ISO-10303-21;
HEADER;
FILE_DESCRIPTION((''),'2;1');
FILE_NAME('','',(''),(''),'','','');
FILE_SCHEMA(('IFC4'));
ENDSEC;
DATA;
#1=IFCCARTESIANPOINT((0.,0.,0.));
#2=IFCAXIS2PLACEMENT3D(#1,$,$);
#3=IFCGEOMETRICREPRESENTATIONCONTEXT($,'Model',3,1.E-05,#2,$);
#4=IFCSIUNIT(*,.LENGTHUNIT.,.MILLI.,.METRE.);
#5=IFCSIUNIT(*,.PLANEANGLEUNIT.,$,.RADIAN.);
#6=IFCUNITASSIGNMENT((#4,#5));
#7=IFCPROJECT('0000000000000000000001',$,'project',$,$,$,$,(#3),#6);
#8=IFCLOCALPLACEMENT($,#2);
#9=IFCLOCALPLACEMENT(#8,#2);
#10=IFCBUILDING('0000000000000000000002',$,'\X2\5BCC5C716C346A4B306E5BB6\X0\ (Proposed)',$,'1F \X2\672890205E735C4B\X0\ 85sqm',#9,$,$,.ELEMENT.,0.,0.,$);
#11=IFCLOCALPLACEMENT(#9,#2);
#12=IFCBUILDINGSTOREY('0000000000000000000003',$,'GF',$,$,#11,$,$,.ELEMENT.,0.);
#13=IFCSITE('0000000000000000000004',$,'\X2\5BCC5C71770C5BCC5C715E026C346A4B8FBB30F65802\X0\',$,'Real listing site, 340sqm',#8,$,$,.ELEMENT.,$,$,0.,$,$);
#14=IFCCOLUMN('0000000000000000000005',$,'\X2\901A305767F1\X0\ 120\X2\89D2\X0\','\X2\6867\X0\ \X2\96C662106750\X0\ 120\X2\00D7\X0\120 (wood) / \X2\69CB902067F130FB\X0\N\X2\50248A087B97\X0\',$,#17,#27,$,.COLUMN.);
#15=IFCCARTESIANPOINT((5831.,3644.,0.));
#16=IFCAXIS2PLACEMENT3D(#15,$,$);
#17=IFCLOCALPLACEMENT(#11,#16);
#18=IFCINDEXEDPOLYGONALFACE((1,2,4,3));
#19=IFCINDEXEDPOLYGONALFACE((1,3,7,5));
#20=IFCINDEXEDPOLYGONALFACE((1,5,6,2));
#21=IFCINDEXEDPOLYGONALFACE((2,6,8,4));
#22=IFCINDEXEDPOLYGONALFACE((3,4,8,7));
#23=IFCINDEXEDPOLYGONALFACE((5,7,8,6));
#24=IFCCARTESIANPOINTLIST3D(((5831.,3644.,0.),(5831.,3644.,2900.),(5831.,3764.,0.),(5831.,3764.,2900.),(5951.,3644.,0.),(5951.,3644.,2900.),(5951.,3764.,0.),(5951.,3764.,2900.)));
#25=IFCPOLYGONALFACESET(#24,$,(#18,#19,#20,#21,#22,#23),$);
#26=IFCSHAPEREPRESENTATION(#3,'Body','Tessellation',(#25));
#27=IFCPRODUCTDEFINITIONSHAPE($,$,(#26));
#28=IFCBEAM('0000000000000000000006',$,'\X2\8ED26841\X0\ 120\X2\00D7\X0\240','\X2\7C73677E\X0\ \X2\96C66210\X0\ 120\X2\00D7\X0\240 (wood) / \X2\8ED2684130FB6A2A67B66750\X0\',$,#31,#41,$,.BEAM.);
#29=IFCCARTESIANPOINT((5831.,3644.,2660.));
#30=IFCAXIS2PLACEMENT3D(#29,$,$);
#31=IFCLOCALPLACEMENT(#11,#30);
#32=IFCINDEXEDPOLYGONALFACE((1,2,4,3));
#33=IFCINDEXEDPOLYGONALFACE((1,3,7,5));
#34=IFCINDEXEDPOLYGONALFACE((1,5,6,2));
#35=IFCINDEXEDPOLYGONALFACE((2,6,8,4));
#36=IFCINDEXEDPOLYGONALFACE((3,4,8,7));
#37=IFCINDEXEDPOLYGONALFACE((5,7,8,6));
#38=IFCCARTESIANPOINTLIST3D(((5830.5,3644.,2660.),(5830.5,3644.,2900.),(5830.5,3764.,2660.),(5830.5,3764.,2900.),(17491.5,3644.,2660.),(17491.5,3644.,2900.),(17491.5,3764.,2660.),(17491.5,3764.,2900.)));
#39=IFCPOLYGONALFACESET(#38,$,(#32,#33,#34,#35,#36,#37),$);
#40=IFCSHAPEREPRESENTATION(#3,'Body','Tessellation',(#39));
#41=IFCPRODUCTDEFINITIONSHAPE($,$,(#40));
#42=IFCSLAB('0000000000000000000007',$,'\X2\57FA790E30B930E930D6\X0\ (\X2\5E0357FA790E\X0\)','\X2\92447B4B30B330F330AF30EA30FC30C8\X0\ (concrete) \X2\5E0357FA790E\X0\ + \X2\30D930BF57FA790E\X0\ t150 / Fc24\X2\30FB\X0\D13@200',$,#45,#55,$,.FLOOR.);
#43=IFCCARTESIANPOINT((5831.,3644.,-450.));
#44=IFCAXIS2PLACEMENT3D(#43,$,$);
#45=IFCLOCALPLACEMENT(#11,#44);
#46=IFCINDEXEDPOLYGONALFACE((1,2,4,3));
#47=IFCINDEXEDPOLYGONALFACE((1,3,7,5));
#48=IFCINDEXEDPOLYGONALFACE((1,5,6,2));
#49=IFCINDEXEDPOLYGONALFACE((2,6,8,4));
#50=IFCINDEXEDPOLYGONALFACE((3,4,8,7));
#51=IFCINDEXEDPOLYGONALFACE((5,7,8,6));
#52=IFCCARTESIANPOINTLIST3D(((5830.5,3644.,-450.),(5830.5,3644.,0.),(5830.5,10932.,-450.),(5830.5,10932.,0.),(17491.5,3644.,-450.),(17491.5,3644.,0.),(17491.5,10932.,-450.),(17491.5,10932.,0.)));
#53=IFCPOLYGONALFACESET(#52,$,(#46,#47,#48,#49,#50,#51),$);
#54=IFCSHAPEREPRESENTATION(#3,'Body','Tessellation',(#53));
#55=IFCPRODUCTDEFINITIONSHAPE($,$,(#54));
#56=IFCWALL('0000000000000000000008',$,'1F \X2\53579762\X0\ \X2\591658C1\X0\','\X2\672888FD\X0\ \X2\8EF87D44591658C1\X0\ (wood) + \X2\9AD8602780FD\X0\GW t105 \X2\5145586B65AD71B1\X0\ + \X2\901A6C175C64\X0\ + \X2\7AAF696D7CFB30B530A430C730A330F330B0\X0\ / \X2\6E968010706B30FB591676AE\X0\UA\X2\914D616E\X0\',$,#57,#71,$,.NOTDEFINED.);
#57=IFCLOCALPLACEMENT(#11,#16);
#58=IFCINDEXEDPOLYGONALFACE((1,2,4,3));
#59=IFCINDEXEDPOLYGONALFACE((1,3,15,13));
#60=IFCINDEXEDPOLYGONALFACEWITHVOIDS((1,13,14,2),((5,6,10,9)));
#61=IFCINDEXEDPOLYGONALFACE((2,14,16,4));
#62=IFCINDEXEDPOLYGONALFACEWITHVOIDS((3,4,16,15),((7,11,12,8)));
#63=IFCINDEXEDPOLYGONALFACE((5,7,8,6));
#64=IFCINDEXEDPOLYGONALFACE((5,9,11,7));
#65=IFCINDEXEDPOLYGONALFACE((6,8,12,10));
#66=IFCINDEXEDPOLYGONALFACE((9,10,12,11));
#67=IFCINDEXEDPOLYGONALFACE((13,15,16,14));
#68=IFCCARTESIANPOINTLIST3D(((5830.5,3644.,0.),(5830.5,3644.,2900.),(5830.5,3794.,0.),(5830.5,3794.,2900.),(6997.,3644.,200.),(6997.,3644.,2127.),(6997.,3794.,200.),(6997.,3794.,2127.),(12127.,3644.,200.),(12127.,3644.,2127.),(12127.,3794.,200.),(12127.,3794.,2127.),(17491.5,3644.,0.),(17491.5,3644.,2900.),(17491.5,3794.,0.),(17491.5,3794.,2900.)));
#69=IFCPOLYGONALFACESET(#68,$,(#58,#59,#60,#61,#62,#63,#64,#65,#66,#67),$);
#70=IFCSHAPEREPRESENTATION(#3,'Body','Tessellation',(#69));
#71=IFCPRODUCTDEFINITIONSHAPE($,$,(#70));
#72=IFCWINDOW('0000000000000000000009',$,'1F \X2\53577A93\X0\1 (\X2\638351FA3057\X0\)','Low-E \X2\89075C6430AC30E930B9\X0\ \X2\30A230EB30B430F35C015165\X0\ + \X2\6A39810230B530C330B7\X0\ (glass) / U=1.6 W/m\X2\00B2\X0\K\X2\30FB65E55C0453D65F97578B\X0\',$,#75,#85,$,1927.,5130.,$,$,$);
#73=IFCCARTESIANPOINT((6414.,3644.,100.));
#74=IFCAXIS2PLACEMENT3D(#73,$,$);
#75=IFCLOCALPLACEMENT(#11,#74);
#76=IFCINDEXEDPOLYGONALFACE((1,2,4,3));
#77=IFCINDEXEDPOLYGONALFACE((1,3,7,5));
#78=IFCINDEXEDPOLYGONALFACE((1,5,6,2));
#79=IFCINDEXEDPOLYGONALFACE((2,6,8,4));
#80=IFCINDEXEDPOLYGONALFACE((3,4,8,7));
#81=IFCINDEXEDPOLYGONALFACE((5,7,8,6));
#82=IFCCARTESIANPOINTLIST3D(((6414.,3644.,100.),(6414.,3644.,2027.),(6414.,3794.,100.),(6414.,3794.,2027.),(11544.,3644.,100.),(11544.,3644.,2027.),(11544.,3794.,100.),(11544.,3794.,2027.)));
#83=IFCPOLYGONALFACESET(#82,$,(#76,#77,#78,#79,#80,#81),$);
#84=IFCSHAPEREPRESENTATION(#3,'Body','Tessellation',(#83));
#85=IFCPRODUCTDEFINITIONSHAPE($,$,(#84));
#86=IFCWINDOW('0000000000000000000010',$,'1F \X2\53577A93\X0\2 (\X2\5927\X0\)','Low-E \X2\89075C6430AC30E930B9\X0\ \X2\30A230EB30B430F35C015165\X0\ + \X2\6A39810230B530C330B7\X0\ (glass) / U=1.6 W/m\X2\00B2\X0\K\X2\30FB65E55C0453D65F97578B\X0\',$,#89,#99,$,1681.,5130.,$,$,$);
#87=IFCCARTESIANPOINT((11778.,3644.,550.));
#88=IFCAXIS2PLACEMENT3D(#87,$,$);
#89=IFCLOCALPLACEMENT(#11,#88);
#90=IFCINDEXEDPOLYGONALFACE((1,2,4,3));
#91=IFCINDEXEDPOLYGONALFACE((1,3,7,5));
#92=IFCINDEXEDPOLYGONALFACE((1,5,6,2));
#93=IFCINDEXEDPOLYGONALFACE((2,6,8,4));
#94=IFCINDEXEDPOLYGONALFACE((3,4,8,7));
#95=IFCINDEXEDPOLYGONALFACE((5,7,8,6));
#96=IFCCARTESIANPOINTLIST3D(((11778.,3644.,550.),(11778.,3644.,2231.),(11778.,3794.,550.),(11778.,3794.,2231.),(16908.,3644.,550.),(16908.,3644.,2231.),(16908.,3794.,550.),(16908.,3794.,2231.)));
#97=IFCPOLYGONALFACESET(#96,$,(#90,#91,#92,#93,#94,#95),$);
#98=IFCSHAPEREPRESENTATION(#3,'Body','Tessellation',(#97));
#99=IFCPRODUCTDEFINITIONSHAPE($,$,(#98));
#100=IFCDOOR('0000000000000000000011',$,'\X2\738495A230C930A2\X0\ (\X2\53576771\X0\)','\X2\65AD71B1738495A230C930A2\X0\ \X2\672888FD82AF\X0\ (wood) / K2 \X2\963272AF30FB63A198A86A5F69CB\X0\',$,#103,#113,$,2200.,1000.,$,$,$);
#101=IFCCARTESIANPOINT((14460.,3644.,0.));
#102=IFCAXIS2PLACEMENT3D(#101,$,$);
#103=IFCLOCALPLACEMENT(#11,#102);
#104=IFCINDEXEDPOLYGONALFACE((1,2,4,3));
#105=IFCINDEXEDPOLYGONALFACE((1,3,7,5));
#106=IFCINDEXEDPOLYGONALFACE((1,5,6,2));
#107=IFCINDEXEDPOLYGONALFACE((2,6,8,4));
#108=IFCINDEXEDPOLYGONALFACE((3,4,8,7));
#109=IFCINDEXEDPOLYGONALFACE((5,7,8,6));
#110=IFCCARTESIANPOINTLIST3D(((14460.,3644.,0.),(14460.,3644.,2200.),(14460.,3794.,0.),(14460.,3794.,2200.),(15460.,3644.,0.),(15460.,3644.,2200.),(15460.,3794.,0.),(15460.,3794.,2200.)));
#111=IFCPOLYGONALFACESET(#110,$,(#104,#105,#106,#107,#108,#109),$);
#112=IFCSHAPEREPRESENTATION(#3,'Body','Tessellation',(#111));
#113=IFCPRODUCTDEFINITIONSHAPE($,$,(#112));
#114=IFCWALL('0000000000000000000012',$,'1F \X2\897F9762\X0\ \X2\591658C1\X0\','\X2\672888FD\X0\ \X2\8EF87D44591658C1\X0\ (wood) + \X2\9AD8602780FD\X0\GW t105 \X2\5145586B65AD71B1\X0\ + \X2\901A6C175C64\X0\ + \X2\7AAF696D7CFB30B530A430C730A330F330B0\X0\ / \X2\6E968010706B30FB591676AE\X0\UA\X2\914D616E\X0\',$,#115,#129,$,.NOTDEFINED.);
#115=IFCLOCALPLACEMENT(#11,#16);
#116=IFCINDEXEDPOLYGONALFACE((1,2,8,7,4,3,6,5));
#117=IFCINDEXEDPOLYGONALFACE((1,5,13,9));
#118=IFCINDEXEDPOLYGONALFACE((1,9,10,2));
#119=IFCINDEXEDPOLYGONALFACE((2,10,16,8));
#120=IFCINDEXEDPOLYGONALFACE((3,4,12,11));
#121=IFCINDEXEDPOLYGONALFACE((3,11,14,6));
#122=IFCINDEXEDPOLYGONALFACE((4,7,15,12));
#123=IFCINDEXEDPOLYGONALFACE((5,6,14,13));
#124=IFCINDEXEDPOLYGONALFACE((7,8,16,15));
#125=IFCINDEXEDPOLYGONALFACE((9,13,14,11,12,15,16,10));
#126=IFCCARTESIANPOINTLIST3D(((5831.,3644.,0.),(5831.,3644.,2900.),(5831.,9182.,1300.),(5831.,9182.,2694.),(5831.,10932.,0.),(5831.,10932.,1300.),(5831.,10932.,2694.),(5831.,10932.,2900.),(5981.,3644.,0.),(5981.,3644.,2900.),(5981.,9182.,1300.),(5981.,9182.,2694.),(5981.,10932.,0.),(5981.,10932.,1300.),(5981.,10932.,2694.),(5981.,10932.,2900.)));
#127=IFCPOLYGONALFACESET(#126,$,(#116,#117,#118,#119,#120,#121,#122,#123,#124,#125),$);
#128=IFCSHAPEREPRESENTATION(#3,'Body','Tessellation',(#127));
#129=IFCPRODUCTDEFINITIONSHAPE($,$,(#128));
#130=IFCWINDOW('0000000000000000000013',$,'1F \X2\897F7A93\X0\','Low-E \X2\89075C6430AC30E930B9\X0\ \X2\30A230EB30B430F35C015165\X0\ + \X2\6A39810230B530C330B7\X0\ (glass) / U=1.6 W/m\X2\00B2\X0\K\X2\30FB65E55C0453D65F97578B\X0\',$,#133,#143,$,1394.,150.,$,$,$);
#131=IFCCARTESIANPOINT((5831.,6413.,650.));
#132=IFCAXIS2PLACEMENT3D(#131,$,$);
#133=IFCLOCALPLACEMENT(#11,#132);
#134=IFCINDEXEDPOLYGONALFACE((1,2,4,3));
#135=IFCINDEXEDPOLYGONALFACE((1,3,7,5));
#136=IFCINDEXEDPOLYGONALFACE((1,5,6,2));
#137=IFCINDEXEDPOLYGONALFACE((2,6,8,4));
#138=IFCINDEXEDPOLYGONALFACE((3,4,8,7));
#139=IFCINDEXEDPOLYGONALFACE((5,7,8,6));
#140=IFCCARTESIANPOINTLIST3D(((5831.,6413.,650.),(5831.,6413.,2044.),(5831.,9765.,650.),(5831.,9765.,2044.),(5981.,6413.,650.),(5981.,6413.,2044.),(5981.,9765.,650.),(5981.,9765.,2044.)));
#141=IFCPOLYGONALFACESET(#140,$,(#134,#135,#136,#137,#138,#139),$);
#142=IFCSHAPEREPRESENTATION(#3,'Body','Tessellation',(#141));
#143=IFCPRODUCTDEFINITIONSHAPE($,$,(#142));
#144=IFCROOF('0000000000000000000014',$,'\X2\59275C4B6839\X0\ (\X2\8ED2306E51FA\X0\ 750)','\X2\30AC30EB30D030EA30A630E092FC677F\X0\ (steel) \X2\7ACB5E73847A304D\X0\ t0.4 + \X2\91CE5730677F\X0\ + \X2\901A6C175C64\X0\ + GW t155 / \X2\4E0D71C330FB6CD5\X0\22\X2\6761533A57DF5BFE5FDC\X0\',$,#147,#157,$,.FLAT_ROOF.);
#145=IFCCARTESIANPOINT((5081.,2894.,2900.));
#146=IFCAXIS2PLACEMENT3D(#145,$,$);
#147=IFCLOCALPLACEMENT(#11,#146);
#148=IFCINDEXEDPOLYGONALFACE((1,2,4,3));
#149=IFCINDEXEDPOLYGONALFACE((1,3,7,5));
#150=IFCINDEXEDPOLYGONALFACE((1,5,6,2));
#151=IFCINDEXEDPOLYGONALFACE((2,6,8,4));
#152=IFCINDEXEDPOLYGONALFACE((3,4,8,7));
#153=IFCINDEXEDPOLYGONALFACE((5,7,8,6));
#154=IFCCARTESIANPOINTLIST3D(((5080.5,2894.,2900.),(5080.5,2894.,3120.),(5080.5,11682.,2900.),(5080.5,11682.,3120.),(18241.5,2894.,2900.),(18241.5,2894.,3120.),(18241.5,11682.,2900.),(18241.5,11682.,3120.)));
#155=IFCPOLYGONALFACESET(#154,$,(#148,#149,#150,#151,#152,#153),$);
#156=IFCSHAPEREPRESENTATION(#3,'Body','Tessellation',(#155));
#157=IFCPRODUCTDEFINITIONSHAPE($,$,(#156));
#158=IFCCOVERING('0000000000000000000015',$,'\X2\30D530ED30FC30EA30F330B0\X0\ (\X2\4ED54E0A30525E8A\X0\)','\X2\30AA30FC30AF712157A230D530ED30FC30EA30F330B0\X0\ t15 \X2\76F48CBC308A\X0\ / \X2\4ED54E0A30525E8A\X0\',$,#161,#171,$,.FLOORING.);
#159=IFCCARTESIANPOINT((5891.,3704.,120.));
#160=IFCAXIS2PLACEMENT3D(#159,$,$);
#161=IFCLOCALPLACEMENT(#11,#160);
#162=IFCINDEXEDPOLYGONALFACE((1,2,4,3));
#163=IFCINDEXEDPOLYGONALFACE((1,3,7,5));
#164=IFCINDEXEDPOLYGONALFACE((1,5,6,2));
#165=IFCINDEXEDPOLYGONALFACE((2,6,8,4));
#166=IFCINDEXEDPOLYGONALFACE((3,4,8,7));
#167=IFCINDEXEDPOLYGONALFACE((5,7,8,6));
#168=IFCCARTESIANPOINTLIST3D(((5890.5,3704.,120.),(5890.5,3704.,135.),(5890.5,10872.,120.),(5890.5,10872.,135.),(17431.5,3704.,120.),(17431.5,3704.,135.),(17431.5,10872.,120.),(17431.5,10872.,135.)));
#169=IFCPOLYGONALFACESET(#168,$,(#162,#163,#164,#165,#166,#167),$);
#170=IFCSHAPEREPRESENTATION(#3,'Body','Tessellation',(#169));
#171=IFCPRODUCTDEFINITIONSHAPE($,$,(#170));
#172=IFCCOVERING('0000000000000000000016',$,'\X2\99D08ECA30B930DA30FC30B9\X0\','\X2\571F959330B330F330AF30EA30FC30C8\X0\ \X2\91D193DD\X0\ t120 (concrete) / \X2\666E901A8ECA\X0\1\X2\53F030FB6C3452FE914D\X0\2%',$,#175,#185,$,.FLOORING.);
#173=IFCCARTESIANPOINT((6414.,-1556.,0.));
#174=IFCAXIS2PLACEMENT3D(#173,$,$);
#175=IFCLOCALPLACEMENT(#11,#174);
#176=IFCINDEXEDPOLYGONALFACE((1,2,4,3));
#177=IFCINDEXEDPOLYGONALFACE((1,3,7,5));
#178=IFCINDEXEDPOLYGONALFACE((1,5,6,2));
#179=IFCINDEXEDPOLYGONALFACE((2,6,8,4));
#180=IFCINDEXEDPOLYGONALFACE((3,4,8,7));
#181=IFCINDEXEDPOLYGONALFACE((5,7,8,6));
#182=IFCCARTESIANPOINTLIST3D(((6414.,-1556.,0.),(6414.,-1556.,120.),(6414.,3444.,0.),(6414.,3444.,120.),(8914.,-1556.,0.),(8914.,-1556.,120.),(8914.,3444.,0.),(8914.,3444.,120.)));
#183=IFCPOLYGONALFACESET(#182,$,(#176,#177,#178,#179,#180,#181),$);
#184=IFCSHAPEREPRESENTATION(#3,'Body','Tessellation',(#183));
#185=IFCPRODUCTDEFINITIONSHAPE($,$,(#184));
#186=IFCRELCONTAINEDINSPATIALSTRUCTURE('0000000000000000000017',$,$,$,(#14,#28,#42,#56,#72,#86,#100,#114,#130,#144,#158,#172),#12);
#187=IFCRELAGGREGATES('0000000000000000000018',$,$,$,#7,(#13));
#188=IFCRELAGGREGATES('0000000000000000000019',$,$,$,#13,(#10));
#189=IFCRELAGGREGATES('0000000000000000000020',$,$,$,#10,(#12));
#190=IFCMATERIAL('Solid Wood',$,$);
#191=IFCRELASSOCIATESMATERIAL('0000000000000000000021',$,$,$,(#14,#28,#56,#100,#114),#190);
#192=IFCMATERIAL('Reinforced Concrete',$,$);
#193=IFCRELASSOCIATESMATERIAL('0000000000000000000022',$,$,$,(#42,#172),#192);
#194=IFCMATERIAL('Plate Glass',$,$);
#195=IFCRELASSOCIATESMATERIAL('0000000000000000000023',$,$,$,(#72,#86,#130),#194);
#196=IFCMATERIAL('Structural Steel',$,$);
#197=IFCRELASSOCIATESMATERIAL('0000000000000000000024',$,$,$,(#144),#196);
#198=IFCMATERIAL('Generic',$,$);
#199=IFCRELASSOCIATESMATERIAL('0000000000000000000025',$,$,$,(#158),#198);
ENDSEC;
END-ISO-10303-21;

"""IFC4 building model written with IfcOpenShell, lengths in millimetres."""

from ifc_helpers import new_model, si_unit, frame, frame_2d, origin, place, context, project, spatial, rectangle, extrude, material, element, fill, save


model = new_model("IFC4")

# Units and contexts
model_context = context("Model", 3, precision=1e-05, world=origin())
ifc_project = project(units=[si_unit("LENGTHUNIT", "METRE", prefix="MILLI"), si_unit("PLANEANGLEUNIT", "RADIAN")], contexts=[model_context])

# Site, building, storey
site_placement = place(None, origin())
site = spatial("IfcSite", under=ifc_project, at=site_placement, Name="富山県富山市水橋辻ヶ堂", ObjectType="Real listing site, 340sqm", CompositionType="ELEMENT", RefElevation=0.0)
building_placement = place(site_placement, origin())
building = spatial("IfcBuilding", under=site, at=building_placement, Name="富山水橋の家 (Proposed)", ObjectType="1F 木造平屋 85sqm", CompositionType="ELEMENT", ElevationOfRefHeight=0.0, ElevationOfTerrain=0.0)
storey_placement = place(building_placement, origin())
storey = spatial("IfcBuildingStorey", under=building, at=storey_placement, Name="GF", CompositionType="ELEMENT", Elevation=0.0)

# Column
ifc_material_1 = material(Name="Solid Wood")
column_1_placement = place(storey_placement, frame((5831.0, 3644.0, 0.0)))
element("IfcColumn", 1, at=column_1_placement, inside=storey, material=ifc_material_1, Name="通し柱 120角", Description="桧 集成材 120×120 (wood) / 構造柱・N値計算", PredefinedType="COLUMN", context=model_context, shape_type="SweptSolid", body=[
    extrude(rectangle(XDim=120.0, YDim=120.0, at=frame_2d((60.0, 60.0))), frame((5831.0, 3644.0, 0.0)), (0.0, 0.0, 1.0), 2900.0),
])

# Beam
beam_1_placement = place(storey_placement, frame((5831.0, 3644.0, 2660.0)))
element("IfcBeam", 2, at=beam_1_placement, inside=storey, material=ifc_material_1, Name="軒桁 120×240", Description="米松 集成 120×240 (wood) / 軒桁・横架材", PredefinedType="BEAM", context=model_context, shape_type="SweptSolid", body=[
    extrude(rectangle(XDim=11661.0, YDim=120.0, at=frame_2d((5830.0, 60.0))), frame((5831.0, 3644.0, 2660.0)), (0.0, 0.0, 1.0), 240.0),
])

# Slab
ifc_material_2 = material(Name="Reinforced Concrete")
slab_1_placement = place(storey_placement, frame((5831.0, 3644.0, -450.0)))
element("IfcSlab", 3, at=slab_1_placement, inside=storey, material=ifc_material_2, Name="基礎スラブ (布基礎)", Description="鉄筋コンクリート (concrete) 布基礎 + ベタ基礎 t150 / Fc24・D13@200", PredefinedType="FLOOR", context=model_context, shape_type="SweptSolid", body=[
    extrude(rectangle(XDim=11661.0, YDim=7288.0, at=frame_2d((5830.0, 3644.0))), frame((5831.0, 3644.0, -450.0)), (0.0, 0.0, 1.0), 450.0),
])

# Wall, openings, windows, door
wall_1_placement = place(storey_placement, frame((5831.0, 3644.0, 0.0)))
wall_1 = element("IfcWall", 4, at=wall_1_placement, inside=storey, material=ifc_material_1, Name="1F 南面 外壁", Description="木製 軸組外壁 (wood) + 高性能GW t105 充填断熱 + 通気層 + 窯業系サイディング / 準耐火・外皮UA配慮", PredefinedType="NOTDEFINED", context=model_context, shape_type="SweptSolid", body=[
    extrude(rectangle(XDim=11661.0, YDim=150.0, at=frame_2d((5830.0, 75.0))), frame((5831.0, 3644.0, 0.0)), (0.0, 0.0, 1.0), 2900.0),
])
opening_1_placement = place(storey_placement, frame((6414.0, 3644.0, 100.0)))
opening_1 = element("IfcOpeningElement", 5, at=opening_1_placement, cuts=wall_1, PredefinedType="NOTDEFINED", context=model_context, shape_type="SweptSolid", body=[
    extrude(rectangle(XDim=5130.0, YDim=150.0, at=frame_2d((2565.0, 75.0))), frame((6414.0, 3644.0, 100.0)), (0.0, 0.0, 1.0), 1927.0),
])
opening_2_placement = place(storey_placement, frame((11778.0, 3644.0, 550.0)))
opening_2 = element("IfcOpeningElement", 6, at=opening_2_placement, cuts=wall_1, PredefinedType="NOTDEFINED", context=model_context, shape_type="SweptSolid", body=[
    extrude(rectangle(XDim=5130.0, YDim=150.0, at=frame_2d((2565.0, 75.0))), frame((11778.0, 3644.0, 550.0)), (0.0, 0.0, 1.0), 1681.0),
])
opening_3_placement = place(storey_placement, frame((14460.0, 3644.0, 0.0)))
opening_3 = element("IfcOpeningElement", 7, at=opening_3_placement, cuts=wall_1, PredefinedType="NOTDEFINED", context=model_context, shape_type="SweptSolid", body=[
    extrude(rectangle(XDim=1000.0, YDim=150.0, at=frame_2d((500.0, 75.0))), frame((14460.0, 3644.0, 0.0)), (0.0, 0.0, 1.0), 2200.0),
])
ifc_material_3 = material(Name="Plate Glass")
window_1_placement = place(storey_placement, frame((6414.0, 3644.0, 100.0)))
window_1 = element("IfcWindow", 8, at=window_1_placement, inside=storey, material=ifc_material_3, Name="1F 南窓1 (掃出し)", Description="Low-E 複層ガラス アルゴン封入 + 樹脂サッシ (glass) / U=1.6 W/m²K・日射取得型", OverallHeight=1927.0, OverallWidth=5130.0, context=model_context, shape_type="SweptSolid", body=[
    extrude(rectangle(XDim=5130.0, YDim=150.0, at=frame_2d((2565.0, 75.0))), frame((6414.0, 3644.0, 100.0)), (0.0, 0.0, 1.0), 1927.0),
])
fill(opening_1, window_1)
window_2_placement = place(storey_placement, frame((11778.0, 3644.0, 550.0)))
window_2 = element("IfcWindow", 9, at=window_2_placement, inside=storey, material=ifc_material_3, Name="1F 南窓2 (大)", Description="Low-E 複層ガラス アルゴン封入 + 樹脂サッシ (glass) / U=1.6 W/m²K・日射取得型", OverallHeight=1681.0, OverallWidth=5130.0, context=model_context, shape_type="SweptSolid", body=[
    extrude(rectangle(XDim=5130.0, YDim=150.0, at=frame_2d((2565.0, 75.0))), frame((11778.0, 3644.0, 550.0)), (0.0, 0.0, 1.0), 1681.0),
])
fill(opening_2, window_2)
door_placement = place(storey_placement, frame((14460.0, 3644.0, 0.0)))
door = element("IfcDoor", 10, at=door_placement, inside=storey, material=ifc_material_1, Name="玄関ドア (南東)", Description="断熱玄関ドア 木製芯 (wood) / K2 防犯・採風機構", OverallHeight=2200.0, OverallWidth=1000.0, context=model_context, shape_type="SweptSolid", body=[
    extrude(rectangle(XDim=1000.0, YDim=150.0, at=frame_2d((500.0, 75.0))), frame((14460.0, 3644.0, 0.0)), (0.0, 0.0, 1.0), 2200.0),
])
fill(opening_3, door)

# Wall, opening, window
wall_2_placement = place(storey_placement, frame((5831.0, 3644.0, 0.0)))
wall_2 = element("IfcWall", 11, at=wall_2_placement, inside=storey, material=ifc_material_1, Name="1F 西面 外壁", Description="木製 軸組外壁 (wood) + 高性能GW t105 充填断熱 + 通気層 + 窯業系サイディング / 準耐火・外皮UA配慮", PredefinedType="NOTDEFINED", context=model_context, shape_type="SweptSolid", body=[
    extrude(rectangle(XDim=150.0, YDim=7288.0, at=frame_2d((75.0, 3644.0))), frame((5831.0, 3644.0, 0.0)), (0.0, 0.0, 1.0), 2900.0),
])
opening_4_placement = place(storey_placement, frame((5831.0, 6413.0, 650.0)))
opening_4 = element("IfcOpeningElement", 12, at=opening_4_placement, cuts=wall_2, PredefinedType="NOTDEFINED", context=model_context, shape_type="SweptSolid", body=[
    extrude(rectangle(XDim=150.0, YDim=3352.0, at=frame_2d((75.0, 1676.0))), frame((5831.0, 6413.0, 650.0)), (0.0, 0.0, 1.0), 1394.0),
])
window_3_placement = place(storey_placement, frame((5831.0, 6413.0, 650.0)))
window_3 = element("IfcWindow", 13, at=window_3_placement, inside=storey, material=ifc_material_3, Name="1F 西窓", Description="Low-E 複層ガラス アルゴン封入 + 樹脂サッシ (glass) / U=1.6 W/m²K・日射取得型", OverallHeight=1394.0, OverallWidth=150.0, context=model_context, shape_type="SweptSolid", body=[
    extrude(rectangle(XDim=150.0, YDim=3352.0, at=frame_2d((75.0, 1676.0))), frame((5831.0, 6413.0, 650.0)), (0.0, 0.0, 1.0), 1394.0),
])
fill(opening_4, window_3)

# Roof
ifc_material_4 = material(Name="Structural Steel")
roof_placement = place(storey_placement, frame((5081.0, 2894.0, 2900.0)))
element("IfcRoof", 14, at=roof_placement, inside=storey, material=ifc_material_4, Name="大屋根 (軒の出 750)", Description="ガルバリウム鋼板 (steel) 立平葺き t0.4 + 野地板 + 通気層 + GW t155 / 不燃・法22条区域対応", PredefinedType="FLAT_ROOF", context=model_context, shape_type="SweptSolid", body=[
    extrude(rectangle(XDim=13161.0, YDim=8788.0, at=frame_2d((6580.0, 4394.0))), frame((5081.0, 2894.0, 2900.0)), (0.0, 0.0, 1.0), 220.0),
])

# Coverings
ifc_material_5 = material(Name="Generic")
covering_1_placement = place(storey_placement, frame((5891.0, 3704.0, 120.0)))
element("IfcCovering", 15, at=covering_1_placement, inside=storey, material=ifc_material_5, Name="フローリング (仕上げ床)", Description="オーク無垢フローリング t15 直貼り / 仕上げ床", PredefinedType="FLOORING", context=model_context, shape_type="SweptSolid", body=[
    extrude(rectangle(XDim=11541.0, YDim=7168.0, at=frame_2d((5770.0, 3584.0))), frame((5891.0, 3704.0, 120.0)), (0.0, 0.0, 1.0), 15.0),
])
covering_2_placement = place(storey_placement, frame((6414.0, -1556.0, 0.0)))
element("IfcCovering", 16, at=covering_2_placement, inside=storey, material=ifc_material_2, Name="駐車スペース", Description="土間コンクリート 金鏝 t120 (concrete) / 普通車1台・水勾配2%", PredefinedType="FLOORING", context=model_context, shape_type="SweptSolid", body=[
    extrude(rectangle(XDim=2500.0, YDim=5000.0, at=frame_2d((1250.0, 2500.0))), frame((6414.0, -1556.0, 0.0)), (0.0, 0.0, 1.0), 120.0),
])

save(model, "model.ifc")
